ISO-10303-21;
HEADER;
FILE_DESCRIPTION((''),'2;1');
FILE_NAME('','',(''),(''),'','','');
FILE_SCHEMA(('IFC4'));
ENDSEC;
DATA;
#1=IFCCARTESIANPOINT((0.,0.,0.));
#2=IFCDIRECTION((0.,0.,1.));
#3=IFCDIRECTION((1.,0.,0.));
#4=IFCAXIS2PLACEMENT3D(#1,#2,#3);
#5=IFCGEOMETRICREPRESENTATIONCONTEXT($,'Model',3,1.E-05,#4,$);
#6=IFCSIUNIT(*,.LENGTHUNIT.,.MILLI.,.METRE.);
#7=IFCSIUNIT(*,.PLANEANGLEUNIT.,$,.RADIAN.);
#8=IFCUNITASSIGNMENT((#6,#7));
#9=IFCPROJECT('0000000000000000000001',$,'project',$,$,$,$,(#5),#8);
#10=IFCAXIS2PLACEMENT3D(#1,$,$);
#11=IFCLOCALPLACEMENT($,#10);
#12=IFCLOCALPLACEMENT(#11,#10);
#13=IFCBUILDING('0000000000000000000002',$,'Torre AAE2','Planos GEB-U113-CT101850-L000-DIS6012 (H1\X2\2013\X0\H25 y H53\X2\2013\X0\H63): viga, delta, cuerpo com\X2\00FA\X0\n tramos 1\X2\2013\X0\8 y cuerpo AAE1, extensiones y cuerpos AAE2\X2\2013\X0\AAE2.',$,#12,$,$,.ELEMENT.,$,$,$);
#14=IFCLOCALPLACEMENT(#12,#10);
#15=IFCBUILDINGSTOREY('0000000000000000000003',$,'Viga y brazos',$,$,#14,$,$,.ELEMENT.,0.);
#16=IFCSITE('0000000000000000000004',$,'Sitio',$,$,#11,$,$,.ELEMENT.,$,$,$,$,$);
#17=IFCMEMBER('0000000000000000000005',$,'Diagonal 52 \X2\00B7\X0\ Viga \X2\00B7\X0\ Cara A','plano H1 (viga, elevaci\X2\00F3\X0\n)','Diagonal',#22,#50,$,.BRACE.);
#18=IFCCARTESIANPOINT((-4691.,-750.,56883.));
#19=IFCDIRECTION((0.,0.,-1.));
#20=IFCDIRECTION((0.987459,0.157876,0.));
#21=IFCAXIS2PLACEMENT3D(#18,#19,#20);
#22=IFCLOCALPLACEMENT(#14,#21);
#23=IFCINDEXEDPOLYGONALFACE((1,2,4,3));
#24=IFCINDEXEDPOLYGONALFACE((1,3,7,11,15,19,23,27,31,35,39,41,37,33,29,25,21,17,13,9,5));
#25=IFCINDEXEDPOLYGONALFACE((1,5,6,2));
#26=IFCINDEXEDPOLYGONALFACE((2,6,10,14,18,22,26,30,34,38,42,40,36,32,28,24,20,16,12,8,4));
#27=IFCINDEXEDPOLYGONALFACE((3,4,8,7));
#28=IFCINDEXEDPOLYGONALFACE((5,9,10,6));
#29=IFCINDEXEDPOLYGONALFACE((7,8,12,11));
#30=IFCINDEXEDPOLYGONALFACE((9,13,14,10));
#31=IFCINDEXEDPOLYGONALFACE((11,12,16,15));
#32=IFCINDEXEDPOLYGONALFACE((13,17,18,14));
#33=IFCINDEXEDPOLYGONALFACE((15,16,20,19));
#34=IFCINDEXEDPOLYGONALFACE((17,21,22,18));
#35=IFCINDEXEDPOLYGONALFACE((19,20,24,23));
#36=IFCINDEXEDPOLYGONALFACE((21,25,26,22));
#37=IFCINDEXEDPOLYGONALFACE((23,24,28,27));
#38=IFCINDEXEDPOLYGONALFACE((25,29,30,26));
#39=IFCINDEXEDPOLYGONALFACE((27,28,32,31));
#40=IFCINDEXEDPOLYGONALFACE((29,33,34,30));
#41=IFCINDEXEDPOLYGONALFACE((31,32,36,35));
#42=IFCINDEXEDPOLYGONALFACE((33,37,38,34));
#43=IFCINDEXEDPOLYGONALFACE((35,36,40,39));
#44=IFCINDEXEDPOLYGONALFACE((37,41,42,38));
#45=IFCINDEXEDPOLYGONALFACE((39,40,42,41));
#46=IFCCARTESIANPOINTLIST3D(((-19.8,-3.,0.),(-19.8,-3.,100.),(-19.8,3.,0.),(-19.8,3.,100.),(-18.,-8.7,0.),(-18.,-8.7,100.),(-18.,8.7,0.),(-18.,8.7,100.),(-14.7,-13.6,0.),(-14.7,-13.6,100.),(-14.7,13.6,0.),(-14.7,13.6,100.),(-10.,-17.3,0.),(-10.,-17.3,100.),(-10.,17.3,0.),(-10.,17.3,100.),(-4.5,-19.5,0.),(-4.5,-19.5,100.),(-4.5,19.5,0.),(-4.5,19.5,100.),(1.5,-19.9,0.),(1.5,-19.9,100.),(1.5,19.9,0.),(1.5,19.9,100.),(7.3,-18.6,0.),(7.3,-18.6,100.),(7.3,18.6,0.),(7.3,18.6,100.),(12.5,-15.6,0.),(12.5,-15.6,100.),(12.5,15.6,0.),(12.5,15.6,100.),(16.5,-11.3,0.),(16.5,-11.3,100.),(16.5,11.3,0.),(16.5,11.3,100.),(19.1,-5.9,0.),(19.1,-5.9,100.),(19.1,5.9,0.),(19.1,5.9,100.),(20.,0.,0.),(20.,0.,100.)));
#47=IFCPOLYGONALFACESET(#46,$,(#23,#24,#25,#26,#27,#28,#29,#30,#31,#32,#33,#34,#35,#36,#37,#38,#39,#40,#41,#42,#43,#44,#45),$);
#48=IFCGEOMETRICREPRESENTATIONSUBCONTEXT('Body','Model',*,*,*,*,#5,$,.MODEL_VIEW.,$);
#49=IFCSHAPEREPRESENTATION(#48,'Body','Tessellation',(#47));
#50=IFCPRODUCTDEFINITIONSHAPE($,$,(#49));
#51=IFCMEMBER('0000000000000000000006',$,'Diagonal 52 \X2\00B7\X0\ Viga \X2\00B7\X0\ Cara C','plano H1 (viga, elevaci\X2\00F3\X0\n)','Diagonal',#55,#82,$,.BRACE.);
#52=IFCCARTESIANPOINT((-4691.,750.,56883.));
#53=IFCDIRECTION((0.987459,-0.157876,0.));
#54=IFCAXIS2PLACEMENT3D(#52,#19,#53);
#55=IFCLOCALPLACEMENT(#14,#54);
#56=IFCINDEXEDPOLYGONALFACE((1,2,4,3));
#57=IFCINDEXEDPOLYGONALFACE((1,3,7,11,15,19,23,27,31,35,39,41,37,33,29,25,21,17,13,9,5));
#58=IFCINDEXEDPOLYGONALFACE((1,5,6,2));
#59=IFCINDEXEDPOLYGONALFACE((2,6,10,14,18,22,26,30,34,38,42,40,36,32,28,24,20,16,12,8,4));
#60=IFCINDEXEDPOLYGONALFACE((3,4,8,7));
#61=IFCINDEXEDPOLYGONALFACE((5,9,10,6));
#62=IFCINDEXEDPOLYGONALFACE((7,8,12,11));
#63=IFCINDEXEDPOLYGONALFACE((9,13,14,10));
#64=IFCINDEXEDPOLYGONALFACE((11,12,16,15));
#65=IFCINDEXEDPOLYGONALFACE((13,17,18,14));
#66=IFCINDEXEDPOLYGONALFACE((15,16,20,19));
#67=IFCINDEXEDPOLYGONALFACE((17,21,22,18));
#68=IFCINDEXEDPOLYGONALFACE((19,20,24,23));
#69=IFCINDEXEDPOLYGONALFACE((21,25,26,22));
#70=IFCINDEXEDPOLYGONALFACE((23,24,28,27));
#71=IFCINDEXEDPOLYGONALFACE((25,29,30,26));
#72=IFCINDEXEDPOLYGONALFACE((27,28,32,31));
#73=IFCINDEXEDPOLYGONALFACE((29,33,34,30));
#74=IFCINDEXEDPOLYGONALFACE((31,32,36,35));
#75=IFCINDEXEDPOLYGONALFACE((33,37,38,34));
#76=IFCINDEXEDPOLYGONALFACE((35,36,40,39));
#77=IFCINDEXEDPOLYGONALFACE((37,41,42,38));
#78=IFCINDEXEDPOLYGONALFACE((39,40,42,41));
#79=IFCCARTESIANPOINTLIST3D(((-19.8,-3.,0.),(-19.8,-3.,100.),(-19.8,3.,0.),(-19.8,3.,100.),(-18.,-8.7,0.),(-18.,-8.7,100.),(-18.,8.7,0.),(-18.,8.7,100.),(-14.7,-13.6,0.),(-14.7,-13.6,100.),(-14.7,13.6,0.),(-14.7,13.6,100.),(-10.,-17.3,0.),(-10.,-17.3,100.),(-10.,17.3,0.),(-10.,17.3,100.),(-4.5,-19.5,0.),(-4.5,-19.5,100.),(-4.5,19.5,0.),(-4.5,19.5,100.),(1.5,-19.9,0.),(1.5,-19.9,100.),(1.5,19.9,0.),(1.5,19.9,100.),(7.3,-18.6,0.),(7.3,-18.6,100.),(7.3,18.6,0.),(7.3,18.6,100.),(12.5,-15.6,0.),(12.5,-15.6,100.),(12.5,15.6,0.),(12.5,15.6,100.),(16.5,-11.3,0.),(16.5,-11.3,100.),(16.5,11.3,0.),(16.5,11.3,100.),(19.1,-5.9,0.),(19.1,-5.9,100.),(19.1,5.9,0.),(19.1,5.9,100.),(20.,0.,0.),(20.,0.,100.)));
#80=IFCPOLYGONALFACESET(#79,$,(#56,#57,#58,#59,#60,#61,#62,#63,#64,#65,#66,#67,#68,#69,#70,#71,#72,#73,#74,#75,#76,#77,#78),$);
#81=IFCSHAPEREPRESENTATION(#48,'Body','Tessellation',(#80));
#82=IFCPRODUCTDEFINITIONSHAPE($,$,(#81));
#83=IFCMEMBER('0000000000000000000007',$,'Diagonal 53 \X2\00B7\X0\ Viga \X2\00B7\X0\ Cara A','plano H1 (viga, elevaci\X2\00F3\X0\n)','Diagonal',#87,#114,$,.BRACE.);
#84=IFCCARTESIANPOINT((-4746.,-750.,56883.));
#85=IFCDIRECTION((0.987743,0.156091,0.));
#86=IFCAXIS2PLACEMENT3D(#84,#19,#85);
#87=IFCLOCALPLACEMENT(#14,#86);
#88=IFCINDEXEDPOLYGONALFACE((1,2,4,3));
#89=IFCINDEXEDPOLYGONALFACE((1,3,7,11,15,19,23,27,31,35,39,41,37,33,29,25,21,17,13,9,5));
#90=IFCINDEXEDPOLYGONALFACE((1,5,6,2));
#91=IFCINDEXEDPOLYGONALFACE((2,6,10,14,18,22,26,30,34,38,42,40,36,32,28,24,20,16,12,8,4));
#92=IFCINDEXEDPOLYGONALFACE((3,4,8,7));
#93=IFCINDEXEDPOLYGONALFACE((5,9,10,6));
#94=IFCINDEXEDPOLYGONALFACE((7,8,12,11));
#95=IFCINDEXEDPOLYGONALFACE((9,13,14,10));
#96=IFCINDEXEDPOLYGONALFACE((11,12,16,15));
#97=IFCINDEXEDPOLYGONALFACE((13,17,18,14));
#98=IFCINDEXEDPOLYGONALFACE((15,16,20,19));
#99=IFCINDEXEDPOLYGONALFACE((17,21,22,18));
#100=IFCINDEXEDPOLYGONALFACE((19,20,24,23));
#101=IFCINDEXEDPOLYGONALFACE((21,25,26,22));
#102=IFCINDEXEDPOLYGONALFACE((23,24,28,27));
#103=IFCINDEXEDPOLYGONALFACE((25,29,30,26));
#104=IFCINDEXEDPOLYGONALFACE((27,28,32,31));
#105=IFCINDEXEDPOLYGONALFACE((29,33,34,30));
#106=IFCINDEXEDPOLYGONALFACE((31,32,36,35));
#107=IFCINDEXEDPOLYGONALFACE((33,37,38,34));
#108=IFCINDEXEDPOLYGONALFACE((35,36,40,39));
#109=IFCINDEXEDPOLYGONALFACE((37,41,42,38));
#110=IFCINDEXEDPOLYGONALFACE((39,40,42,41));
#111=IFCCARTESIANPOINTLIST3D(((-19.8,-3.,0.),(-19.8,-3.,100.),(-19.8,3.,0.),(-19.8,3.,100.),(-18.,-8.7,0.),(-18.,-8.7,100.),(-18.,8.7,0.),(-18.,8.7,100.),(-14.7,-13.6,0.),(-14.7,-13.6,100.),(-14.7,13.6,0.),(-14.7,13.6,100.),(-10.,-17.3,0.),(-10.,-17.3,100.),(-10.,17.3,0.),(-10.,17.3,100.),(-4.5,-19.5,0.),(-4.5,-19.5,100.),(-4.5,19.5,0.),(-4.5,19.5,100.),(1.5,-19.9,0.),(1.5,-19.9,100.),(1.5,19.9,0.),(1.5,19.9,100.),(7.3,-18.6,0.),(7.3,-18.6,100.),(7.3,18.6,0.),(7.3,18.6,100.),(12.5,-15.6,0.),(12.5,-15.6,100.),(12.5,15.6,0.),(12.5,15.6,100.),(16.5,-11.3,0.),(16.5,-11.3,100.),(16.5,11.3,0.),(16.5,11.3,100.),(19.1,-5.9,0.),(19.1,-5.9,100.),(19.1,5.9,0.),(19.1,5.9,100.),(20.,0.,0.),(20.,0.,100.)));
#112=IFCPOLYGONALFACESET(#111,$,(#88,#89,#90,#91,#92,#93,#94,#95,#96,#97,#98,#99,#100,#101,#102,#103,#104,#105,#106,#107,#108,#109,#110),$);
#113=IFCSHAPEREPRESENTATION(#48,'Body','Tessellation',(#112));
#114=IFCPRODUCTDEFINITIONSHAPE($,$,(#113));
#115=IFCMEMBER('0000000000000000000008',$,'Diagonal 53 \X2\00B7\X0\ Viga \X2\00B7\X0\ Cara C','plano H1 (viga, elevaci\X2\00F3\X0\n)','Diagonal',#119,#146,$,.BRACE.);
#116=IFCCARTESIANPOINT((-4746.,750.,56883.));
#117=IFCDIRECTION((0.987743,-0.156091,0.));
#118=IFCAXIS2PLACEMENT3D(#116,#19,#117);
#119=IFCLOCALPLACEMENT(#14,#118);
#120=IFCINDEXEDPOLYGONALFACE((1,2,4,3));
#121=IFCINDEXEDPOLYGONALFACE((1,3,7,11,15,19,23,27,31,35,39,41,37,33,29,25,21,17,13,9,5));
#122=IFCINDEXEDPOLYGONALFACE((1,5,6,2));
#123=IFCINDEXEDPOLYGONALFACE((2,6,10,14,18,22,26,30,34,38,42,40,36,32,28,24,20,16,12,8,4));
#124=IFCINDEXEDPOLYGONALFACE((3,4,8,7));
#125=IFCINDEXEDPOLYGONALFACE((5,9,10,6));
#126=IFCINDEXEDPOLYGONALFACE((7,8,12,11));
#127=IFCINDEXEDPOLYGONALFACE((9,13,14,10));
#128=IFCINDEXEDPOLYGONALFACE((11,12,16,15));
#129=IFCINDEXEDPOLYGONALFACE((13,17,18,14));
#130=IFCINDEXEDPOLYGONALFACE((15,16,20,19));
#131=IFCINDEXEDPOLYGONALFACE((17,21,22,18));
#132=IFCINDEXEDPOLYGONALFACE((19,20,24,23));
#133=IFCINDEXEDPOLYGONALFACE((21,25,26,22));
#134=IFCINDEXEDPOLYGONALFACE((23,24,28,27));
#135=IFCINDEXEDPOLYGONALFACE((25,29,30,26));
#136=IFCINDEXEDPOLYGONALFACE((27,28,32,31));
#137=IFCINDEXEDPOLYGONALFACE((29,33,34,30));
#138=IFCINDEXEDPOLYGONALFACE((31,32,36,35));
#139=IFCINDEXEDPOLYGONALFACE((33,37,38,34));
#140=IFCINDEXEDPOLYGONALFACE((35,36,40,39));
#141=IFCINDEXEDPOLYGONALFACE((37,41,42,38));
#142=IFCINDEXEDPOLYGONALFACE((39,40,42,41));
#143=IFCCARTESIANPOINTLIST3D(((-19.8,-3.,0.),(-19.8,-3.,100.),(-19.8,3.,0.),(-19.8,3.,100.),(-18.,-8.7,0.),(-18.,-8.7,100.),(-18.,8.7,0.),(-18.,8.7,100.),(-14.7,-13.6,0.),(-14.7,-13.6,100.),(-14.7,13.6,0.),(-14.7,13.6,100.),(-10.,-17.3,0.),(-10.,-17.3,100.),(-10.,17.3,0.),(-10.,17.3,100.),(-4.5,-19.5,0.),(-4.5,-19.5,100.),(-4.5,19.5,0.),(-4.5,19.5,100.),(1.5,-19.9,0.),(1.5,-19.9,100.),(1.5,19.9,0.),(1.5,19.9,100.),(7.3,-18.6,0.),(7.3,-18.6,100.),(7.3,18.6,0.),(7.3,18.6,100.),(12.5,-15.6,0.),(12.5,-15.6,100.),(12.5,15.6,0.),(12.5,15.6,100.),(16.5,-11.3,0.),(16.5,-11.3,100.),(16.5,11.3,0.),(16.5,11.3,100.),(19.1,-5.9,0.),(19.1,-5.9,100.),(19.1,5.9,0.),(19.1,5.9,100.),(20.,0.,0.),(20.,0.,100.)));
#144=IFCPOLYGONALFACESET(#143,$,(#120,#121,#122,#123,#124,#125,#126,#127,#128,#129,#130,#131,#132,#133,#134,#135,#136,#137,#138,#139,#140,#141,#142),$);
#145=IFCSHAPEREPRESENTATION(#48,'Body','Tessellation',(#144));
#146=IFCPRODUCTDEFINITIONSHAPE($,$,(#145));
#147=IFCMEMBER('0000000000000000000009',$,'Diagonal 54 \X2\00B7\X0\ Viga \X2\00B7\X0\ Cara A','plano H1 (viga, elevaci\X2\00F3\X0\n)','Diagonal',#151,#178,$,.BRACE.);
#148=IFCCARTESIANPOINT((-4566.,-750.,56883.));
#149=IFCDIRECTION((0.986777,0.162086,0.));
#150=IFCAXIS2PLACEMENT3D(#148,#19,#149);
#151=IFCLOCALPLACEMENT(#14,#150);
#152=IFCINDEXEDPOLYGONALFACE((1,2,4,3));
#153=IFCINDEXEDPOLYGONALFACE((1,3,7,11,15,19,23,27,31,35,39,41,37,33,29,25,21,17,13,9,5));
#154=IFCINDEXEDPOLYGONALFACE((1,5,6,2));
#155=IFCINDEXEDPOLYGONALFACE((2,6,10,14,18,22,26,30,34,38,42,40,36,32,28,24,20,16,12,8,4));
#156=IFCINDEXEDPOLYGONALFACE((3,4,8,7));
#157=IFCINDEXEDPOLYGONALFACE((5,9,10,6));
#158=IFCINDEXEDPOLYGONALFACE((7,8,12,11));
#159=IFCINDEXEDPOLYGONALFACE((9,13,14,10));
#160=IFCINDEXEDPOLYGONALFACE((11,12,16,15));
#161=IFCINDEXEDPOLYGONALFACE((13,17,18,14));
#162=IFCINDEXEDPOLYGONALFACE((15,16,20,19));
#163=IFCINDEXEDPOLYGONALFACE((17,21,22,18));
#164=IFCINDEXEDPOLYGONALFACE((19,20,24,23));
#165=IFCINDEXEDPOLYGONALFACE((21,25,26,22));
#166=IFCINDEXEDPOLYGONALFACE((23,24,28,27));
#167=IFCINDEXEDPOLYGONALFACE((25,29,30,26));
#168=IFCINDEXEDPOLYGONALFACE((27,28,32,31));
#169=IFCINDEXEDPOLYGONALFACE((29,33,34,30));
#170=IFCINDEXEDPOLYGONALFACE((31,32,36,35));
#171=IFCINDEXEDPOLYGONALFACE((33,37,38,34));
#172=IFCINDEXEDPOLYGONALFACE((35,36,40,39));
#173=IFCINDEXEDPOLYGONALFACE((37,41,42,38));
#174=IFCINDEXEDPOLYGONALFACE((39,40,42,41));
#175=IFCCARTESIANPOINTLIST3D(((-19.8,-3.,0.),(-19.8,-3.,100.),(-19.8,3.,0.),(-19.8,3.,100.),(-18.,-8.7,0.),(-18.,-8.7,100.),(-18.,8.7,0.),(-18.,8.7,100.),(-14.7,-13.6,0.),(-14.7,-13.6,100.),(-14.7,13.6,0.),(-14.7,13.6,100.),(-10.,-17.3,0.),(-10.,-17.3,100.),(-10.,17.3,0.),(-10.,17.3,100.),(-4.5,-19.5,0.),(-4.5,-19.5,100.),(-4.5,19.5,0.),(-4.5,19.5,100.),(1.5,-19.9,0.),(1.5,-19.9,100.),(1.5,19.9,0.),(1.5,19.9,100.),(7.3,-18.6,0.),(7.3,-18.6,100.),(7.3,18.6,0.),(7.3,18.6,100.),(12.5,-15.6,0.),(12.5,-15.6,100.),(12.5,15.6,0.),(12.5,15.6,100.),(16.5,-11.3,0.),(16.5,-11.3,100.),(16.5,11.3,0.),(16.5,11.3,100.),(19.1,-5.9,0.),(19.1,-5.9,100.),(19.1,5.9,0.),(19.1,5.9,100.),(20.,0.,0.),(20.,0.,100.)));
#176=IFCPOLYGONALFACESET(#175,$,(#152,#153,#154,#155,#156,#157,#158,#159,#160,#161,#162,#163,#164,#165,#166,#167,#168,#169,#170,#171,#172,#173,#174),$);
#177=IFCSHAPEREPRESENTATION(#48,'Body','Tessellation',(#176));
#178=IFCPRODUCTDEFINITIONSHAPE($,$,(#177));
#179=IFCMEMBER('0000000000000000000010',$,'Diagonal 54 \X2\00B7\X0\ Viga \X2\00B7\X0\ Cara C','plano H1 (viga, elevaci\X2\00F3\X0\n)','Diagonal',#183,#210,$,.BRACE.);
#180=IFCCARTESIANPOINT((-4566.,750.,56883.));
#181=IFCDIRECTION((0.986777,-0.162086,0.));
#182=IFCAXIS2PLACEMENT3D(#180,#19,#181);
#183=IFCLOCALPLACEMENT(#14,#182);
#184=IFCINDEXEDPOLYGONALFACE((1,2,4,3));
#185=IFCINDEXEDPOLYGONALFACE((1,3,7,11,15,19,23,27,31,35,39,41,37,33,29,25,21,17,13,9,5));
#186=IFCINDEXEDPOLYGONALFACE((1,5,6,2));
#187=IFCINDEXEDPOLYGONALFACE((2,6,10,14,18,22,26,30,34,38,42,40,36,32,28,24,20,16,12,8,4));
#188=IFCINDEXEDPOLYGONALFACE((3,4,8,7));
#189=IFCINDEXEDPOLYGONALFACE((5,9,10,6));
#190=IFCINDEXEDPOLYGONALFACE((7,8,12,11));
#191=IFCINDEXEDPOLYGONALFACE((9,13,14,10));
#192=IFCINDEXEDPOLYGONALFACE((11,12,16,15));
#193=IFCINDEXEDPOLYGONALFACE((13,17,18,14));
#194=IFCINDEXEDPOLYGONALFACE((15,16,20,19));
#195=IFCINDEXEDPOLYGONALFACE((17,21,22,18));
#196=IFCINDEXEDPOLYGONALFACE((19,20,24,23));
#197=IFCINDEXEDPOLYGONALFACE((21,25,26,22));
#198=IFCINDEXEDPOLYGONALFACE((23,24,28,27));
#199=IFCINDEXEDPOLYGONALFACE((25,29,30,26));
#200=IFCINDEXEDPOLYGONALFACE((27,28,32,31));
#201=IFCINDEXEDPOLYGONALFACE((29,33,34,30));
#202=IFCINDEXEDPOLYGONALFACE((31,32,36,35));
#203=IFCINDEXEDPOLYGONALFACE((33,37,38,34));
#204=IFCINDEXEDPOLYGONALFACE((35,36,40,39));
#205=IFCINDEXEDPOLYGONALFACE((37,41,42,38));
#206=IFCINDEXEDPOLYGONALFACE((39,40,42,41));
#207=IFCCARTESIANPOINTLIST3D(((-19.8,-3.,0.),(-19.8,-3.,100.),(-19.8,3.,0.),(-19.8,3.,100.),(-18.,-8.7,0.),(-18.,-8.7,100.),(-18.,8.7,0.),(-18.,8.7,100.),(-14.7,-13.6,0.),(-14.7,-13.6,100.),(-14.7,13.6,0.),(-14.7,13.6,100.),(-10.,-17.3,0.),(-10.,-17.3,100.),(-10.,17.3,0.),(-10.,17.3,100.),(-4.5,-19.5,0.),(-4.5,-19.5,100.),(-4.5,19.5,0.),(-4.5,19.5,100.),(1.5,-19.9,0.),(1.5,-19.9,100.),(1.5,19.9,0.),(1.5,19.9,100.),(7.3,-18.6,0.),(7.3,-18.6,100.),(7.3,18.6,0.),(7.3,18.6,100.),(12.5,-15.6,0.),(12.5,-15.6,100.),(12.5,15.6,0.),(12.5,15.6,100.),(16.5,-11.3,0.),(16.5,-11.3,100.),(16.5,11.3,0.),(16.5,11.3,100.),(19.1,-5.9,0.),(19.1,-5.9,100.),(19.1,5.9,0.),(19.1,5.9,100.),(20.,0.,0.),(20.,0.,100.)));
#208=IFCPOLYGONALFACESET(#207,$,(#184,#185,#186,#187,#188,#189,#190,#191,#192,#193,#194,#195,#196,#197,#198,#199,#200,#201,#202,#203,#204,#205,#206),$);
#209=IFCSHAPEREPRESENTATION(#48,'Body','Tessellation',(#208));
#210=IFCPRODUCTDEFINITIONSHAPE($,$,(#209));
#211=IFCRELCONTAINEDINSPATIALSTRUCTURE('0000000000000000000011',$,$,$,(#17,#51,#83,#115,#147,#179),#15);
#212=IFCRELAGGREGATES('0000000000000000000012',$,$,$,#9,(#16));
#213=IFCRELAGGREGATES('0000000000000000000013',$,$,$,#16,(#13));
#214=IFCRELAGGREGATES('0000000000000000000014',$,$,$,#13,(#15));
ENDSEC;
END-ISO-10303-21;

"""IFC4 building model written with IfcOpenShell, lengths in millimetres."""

from ifc_helpers import new_model, si_unit, frame, origin, origin_with_axes, place, context, subcontext, project, spatial, circle, extrude, element, save


model = new_model("IFC4")

# Units and contexts
model_context = context("Model", 3, precision=1e-05, world=origin_with_axes())
body_context = subcontext(model_context, "Body", "Model", "MODEL_VIEW")
ifc_project = project(units=[si_unit("LENGTHUNIT", "METRE", prefix="MILLI"), si_unit("PLANEANGLEUNIT", "RADIAN")], contexts=[model_context])

# Site, building, storey
site_placement = place(None, origin())
site = spatial("IfcSite", under=ifc_project, at=site_placement, Name="Sitio", CompositionType="ELEMENT")
building_placement = place(site_placement, origin())
building = spatial("IfcBuilding", under=site, at=building_placement, Name="Torre AAE2", Description="Planos GEB-U113-CT101850-L000-DIS6012 (H1–H25 y H53–H63): viga, delta, cuerpo común tramos 1–8 y cuerpo AAE1, extensiones y cuerpos AAE2–AAE2.", CompositionType="ELEMENT")
storey_placement = place(building_placement, origin())
storey = spatial("IfcBuildingStorey", under=building, at=storey_placement, Name="Viga y brazos", CompositionType="ELEMENT", Elevation=0.0)

# Members
for number, where, z_axis, x_axis, name in (
    (1, (-4691.0, -750.0, 56883.0), (0.0, 0.0, -1.0), (0.987459, 0.157876, 0.0), "Diagonal 52 · Viga · Cara A"),
    (2, (-4691.0, 750.0, 56883.0), (0.0, 0.0, -1.0), (0.987459, -0.157876, 0.0), "Diagonal 52 · Viga · Cara C"),
    (3, (-4746.0, -750.0, 56883.0), (0.0, 0.0, -1.0), (0.987743, 0.156091, 0.0), "Diagonal 53 · Viga · Cara A"),
    (4, (-4746.0, 750.0, 56883.0), (0.0, 0.0, -1.0), (0.987743, -0.156091, 0.0), "Diagonal 53 · Viga · Cara C"),
    (5, (-4566.0, -750.0, 56883.0), (0.0, 0.0, -1.0), (0.986777, 0.162086, 0.0), "Diagonal 54 · Viga · Cara A"),
    (6, (-4566.0, 750.0, 56883.0), (0.0, 0.0, -1.0), (0.986777, -0.162086, 0.0), "Diagonal 54 · Viga · Cara C"),
):
    element("IfcMember", number, at=place(storey_placement, frame(where, z_axis=z_axis, x_axis=x_axis)), inside=storey, Name=name, Description="plano H1 (viga, elevación)", ObjectType="Diagonal", PredefinedType="BRACE", context=body_context, shape_type="SweptSolid", body=[
        extrude(circle(Radius=20.0), None, (0.0, 0.0, 1.0), 100.0),
    ])

save(model, "model.ifc")
